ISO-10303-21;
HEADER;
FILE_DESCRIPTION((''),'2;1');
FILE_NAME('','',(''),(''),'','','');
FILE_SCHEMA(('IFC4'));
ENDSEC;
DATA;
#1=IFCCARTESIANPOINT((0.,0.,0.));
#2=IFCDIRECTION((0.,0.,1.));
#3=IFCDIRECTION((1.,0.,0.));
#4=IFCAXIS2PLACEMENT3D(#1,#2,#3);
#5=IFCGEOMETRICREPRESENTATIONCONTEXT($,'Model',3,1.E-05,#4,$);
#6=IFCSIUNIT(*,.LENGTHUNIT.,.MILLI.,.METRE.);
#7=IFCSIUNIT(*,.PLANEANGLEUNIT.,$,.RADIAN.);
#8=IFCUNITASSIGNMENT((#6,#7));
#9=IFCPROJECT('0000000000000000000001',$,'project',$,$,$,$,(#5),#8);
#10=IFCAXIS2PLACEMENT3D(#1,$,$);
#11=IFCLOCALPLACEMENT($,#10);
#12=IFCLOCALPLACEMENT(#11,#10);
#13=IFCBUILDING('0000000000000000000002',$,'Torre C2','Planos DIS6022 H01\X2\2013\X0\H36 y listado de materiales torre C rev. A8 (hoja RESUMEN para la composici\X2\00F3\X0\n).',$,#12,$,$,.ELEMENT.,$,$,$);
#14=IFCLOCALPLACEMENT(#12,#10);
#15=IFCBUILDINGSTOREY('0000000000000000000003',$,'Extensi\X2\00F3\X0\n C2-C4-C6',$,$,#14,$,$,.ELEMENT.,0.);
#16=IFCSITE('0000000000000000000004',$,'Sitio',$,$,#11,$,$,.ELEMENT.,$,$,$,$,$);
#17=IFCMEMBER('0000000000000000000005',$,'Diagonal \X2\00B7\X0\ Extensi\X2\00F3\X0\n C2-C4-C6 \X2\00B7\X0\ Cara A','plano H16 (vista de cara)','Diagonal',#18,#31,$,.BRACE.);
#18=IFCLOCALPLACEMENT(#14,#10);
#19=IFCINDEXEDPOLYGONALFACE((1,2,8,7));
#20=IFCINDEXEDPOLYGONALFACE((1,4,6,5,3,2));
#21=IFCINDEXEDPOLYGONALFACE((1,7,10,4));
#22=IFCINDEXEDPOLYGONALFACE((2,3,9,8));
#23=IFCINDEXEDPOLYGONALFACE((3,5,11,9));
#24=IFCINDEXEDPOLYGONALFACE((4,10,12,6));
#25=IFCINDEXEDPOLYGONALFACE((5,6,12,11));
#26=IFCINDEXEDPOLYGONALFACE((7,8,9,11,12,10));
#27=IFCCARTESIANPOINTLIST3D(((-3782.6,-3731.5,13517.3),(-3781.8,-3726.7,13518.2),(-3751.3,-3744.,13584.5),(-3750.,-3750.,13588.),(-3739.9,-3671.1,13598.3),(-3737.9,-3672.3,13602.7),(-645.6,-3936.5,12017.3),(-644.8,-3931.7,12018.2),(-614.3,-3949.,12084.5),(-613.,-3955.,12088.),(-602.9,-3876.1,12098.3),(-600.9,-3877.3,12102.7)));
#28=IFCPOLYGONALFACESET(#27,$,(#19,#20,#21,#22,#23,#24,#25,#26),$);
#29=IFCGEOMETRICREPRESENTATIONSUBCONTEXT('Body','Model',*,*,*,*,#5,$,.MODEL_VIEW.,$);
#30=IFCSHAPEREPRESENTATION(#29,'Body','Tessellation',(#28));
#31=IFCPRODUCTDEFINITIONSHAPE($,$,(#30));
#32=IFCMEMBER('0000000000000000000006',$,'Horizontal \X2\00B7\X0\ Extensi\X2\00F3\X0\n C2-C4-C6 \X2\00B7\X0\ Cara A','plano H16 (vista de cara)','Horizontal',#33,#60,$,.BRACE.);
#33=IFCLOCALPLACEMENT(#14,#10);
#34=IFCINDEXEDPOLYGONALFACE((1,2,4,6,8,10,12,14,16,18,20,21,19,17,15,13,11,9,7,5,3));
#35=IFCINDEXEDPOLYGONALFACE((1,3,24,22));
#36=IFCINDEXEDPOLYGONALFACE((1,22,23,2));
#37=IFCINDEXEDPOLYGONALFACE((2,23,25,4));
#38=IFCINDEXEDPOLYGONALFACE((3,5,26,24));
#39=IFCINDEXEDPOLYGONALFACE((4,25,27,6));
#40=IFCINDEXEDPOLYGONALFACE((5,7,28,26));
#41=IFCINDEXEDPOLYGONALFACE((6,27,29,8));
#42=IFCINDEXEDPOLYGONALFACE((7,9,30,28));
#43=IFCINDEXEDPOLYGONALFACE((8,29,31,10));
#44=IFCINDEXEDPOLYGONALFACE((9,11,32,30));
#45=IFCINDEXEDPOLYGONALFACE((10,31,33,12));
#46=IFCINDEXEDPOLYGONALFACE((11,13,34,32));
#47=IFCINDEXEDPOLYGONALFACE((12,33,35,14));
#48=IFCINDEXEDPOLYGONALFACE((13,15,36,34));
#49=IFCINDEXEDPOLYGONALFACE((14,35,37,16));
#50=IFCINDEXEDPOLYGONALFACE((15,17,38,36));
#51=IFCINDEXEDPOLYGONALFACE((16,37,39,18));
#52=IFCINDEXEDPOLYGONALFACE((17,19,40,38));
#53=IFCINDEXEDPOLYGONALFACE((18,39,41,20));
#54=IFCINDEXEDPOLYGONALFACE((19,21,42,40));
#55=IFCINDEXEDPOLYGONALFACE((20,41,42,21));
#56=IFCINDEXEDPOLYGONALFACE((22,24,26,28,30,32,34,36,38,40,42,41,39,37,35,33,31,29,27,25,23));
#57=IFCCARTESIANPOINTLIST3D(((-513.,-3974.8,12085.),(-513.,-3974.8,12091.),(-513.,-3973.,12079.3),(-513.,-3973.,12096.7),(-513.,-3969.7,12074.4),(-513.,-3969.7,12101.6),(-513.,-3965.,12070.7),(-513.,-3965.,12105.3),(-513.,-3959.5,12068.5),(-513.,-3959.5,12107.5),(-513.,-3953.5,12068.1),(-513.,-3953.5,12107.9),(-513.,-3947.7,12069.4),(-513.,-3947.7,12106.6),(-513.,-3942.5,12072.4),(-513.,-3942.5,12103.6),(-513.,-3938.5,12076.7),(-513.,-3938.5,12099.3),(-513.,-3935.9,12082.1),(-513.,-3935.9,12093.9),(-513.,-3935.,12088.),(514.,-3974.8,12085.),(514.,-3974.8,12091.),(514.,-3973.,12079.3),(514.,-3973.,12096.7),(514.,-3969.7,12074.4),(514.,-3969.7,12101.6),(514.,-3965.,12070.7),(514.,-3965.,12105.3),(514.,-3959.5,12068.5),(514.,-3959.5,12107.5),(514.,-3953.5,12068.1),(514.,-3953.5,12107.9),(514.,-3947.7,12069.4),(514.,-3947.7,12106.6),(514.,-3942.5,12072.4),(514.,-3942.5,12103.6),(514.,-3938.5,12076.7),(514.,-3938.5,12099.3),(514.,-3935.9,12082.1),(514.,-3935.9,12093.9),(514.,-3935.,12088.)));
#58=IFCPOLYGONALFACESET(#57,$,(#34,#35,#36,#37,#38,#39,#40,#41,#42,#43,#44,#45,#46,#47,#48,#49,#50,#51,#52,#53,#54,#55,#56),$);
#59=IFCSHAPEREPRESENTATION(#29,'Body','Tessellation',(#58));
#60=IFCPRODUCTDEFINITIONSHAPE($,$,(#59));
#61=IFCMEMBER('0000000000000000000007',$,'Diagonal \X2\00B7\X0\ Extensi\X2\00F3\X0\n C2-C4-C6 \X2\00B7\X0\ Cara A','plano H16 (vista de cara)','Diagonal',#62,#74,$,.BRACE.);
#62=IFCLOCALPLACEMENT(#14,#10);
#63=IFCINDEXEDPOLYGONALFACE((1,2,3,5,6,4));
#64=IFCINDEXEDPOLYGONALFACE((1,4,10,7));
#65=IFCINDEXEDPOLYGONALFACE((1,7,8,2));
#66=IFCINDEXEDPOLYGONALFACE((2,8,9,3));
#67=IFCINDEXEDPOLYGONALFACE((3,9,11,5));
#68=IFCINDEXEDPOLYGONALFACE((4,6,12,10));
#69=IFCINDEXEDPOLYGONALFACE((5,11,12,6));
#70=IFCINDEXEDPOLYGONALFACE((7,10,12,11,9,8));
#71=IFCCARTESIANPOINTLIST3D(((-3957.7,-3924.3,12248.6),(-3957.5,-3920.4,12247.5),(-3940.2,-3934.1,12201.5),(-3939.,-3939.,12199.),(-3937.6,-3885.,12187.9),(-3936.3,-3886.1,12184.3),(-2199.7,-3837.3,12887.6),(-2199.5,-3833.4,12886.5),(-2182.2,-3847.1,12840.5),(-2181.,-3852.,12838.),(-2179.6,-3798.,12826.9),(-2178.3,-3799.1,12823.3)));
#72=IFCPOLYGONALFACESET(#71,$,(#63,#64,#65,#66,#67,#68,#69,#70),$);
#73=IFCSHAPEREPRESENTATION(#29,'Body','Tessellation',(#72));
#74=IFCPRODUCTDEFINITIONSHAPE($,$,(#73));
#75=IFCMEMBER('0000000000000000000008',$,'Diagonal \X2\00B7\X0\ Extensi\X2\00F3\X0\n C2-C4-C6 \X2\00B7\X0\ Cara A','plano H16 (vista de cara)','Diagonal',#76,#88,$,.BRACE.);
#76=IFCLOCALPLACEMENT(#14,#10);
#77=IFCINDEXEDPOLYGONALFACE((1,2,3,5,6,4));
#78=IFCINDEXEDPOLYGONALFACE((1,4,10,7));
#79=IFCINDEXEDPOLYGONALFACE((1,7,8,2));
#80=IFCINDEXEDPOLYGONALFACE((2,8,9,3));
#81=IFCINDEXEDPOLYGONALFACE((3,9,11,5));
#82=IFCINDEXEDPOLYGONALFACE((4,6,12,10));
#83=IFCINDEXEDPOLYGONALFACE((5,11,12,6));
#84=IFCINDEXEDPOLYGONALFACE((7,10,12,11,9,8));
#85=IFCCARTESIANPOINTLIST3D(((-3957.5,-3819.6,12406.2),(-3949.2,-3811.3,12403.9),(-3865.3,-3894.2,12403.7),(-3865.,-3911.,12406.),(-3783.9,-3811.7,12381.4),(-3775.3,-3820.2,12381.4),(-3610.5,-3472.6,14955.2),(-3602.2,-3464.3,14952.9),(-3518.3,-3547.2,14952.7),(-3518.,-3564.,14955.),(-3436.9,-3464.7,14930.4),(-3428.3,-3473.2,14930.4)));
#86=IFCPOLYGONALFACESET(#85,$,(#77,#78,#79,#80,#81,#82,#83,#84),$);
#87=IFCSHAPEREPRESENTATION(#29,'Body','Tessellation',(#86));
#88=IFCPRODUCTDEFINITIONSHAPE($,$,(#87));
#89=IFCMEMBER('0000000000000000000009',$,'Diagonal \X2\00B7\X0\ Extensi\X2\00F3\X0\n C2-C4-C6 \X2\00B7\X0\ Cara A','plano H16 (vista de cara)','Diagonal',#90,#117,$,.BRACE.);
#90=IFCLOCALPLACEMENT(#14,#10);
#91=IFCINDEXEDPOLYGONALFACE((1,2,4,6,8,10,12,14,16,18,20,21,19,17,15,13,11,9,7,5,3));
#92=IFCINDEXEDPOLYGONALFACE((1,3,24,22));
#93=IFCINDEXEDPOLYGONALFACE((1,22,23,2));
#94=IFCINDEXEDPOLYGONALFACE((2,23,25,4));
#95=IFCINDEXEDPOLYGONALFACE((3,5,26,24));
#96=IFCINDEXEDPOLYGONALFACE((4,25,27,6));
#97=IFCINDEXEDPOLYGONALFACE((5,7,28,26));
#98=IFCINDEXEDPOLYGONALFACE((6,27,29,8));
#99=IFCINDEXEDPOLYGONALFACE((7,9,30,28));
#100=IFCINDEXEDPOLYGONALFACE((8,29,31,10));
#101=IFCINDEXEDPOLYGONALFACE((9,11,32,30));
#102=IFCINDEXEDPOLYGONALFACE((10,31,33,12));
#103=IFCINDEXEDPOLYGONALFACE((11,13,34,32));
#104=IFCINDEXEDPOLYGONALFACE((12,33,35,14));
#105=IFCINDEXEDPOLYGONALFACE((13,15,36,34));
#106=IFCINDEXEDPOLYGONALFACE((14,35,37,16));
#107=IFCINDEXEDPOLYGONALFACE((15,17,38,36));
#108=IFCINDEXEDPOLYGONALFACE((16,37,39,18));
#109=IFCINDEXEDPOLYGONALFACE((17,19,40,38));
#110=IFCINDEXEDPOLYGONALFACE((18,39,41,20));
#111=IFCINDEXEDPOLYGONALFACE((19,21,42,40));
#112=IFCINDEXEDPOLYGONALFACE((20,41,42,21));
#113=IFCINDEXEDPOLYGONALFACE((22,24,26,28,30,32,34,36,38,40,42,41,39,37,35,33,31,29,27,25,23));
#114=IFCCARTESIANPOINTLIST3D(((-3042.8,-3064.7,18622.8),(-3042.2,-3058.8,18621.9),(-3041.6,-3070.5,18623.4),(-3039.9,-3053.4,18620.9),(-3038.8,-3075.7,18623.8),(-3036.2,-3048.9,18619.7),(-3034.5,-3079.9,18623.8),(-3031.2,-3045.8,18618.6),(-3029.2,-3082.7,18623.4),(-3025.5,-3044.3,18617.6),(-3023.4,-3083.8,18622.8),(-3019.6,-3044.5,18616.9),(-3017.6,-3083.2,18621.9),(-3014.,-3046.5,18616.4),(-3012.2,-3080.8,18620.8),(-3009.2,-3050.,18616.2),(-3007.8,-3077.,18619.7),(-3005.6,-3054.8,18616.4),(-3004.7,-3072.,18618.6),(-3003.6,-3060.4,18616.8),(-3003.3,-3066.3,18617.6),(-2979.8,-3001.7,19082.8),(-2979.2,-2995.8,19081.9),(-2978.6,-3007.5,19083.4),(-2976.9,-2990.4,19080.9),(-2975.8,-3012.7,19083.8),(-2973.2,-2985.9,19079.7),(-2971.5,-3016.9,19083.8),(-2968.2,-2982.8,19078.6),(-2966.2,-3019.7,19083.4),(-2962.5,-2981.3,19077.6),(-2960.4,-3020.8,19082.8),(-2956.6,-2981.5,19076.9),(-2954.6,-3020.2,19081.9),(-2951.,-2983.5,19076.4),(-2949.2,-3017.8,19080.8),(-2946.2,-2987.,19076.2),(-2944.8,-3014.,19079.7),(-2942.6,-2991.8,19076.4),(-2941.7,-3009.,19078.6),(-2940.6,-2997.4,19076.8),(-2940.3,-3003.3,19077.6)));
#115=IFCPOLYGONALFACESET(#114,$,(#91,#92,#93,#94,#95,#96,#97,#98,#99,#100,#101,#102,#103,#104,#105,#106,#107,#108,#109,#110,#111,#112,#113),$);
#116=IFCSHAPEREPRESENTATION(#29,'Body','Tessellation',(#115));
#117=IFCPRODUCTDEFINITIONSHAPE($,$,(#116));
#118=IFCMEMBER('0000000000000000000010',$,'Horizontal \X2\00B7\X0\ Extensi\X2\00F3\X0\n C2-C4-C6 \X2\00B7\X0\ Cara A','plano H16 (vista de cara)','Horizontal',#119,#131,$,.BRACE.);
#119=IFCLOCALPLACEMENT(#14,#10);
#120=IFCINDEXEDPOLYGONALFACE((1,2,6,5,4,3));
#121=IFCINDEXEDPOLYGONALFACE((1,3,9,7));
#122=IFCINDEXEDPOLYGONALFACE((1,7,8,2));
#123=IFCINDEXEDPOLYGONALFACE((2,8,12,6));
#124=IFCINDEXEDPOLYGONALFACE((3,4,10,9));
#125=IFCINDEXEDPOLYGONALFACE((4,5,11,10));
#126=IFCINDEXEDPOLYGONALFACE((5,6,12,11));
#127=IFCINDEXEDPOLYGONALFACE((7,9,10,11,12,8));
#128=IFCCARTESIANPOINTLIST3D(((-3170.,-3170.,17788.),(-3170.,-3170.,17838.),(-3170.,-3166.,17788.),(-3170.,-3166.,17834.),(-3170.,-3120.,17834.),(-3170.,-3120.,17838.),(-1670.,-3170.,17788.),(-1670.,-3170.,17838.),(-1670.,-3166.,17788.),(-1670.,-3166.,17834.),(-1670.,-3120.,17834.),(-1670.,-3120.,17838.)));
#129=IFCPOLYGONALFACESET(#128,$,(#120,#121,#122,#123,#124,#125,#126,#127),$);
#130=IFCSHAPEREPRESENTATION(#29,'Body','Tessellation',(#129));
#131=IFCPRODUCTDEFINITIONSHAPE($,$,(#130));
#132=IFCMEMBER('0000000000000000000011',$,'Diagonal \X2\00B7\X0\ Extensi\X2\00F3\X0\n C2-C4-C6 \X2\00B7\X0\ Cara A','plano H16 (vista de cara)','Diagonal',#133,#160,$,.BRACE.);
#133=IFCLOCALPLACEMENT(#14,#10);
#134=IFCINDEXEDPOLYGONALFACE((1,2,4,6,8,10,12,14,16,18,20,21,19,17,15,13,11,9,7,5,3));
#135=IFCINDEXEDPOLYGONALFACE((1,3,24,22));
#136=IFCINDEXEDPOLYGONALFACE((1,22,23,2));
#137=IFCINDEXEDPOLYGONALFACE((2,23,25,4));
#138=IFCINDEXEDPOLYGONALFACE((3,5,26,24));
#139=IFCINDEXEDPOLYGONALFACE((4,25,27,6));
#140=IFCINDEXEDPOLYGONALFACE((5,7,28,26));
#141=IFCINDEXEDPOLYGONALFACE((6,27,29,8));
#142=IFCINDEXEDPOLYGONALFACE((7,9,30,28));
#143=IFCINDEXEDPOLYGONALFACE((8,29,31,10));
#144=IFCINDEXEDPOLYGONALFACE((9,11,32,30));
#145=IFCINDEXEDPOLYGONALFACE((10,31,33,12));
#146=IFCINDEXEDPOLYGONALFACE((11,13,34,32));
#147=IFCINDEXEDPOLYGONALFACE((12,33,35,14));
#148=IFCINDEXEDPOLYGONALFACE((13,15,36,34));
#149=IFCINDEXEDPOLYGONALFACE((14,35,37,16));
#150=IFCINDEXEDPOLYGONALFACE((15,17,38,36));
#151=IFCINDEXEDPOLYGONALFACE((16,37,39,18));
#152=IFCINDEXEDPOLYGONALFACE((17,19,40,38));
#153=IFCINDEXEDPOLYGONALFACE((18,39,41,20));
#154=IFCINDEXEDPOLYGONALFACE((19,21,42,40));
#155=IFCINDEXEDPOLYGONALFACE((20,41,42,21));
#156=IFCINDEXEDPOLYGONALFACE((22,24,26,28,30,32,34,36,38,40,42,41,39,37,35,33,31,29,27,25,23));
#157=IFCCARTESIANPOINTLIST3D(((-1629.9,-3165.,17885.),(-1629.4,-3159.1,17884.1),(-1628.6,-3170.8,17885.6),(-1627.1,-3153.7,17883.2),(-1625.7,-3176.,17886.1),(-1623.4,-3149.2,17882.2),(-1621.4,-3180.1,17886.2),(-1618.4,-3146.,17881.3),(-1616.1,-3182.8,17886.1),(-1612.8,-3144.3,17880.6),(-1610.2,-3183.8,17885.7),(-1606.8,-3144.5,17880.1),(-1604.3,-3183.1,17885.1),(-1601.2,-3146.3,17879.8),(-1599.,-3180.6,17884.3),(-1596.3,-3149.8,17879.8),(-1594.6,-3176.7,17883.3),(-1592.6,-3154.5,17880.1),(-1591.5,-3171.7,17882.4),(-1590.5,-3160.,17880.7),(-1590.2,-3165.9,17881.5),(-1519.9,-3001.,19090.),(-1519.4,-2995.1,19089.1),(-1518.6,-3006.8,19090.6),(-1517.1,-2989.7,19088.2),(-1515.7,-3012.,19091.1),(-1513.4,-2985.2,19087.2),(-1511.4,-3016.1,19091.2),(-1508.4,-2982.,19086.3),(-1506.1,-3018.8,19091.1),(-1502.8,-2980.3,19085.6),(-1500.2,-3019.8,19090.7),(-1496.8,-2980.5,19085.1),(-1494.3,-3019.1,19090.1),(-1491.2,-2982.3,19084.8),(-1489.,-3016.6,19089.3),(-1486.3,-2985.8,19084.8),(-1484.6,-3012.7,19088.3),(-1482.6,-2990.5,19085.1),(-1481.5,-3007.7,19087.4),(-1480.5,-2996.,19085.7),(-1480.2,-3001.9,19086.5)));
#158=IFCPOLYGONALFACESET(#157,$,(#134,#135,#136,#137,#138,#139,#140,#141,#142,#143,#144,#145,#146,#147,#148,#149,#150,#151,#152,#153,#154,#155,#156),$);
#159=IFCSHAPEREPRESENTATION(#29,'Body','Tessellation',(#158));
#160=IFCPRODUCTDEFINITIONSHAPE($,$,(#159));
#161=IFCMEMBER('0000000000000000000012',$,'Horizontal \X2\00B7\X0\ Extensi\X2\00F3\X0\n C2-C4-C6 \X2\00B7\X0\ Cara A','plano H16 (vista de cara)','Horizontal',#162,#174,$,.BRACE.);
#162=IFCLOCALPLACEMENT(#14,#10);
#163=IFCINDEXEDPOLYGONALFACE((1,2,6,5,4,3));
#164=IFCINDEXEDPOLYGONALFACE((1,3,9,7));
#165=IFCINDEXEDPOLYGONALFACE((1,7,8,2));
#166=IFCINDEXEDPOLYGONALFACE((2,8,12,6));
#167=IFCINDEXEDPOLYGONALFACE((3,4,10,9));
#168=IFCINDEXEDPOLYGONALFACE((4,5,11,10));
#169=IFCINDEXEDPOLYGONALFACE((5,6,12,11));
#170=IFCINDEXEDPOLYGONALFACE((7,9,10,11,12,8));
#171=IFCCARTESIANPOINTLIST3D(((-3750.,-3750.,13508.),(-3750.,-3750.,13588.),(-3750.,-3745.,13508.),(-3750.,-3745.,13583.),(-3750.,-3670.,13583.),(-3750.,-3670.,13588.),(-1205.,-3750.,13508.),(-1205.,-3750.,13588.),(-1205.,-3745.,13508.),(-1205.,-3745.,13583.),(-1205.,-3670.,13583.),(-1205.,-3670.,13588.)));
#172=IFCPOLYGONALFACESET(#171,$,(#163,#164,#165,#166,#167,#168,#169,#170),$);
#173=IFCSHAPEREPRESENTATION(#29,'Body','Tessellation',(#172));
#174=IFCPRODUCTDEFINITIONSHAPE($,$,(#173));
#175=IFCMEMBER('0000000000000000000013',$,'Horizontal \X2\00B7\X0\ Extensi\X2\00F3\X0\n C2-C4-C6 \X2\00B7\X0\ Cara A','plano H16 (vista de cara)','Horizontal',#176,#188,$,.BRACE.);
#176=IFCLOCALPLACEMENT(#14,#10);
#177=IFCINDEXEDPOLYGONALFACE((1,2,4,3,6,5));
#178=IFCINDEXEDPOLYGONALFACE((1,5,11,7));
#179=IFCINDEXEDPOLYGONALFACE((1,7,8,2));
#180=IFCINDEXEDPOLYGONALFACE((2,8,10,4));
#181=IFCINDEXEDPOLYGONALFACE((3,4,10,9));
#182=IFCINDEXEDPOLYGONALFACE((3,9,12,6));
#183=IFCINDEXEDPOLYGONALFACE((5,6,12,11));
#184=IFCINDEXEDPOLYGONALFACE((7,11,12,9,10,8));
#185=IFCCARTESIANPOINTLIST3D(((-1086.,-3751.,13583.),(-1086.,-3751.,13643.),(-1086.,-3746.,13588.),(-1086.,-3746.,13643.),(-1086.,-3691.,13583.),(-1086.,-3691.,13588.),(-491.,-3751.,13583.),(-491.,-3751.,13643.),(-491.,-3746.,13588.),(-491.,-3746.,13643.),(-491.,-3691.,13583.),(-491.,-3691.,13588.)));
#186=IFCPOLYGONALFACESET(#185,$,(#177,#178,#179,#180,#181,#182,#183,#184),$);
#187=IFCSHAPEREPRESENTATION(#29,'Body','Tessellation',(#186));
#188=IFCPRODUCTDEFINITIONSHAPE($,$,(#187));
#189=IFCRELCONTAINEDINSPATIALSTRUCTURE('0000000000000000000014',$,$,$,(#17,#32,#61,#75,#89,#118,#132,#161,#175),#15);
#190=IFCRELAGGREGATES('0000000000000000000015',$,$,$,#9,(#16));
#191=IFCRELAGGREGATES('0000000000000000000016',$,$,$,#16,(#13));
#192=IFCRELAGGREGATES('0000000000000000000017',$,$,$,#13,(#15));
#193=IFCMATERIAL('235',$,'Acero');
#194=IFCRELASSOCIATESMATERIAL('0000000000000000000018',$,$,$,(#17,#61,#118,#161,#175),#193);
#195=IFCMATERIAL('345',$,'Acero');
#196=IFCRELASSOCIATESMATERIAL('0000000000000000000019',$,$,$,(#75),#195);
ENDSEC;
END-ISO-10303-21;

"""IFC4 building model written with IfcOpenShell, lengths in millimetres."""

from ifc_helpers import new_model, si_unit, frame, frame_2d, origin, origin_with_axes, place, context, subcontext, project, spatial, circle, l_section, extrude, material, element, save


model = new_model("IFC4")

# Units and contexts
model_context = context("Model", 3, precision=1e-05, world=origin_with_axes())
body_context = subcontext(model_context, "Body", "Model", "MODEL_VIEW")
ifc_project = project(units=[si_unit("LENGTHUNIT", "METRE", prefix="MILLI"), si_unit("PLANEANGLEUNIT", "RADIAN")], contexts=[model_context])

# Site, building, storey
site_placement = place(None, origin())
site = spatial("IfcSite", under=ifc_project, at=site_placement, Name="Sitio", CompositionType="ELEMENT")
building_placement = place(site_placement, origin())
building = spatial("IfcBuilding", under=site, at=building_placement, Name="Torre C2", Description="Planos DIS6022 H01–H36 y listado de materiales torre C rev. A8 (hoja RESUMEN para la composición).", CompositionType="ELEMENT")
storey_placement = place(building_placement, origin())
storey = spatial("IfcBuildingStorey", under=building, at=storey_placement, Name="Extensión C2-C4-C6", CompositionType="ELEMENT", Elevation=0.0)

# Members
ifc_material_1 = material(Name="235", Category="Acero")
member_1_placement = place(storey_placement, frame((-613.0, -3955.0, 12088.0), z_axis=(-0.900604, 0.058854, 0.430637), x_axis=(0.151357, 0.971241, 0.183801)))
element("IfcMember", 1, at=member_1_placement, inside=storey, material=ifc_material_1, Name="Diagonal · Extensión C2-C4-C6 · Cara A", Description="plano H16 (vista de cara)", ObjectType="Diagonal", PredefinedType="BRACE", context=body_context, shape_type="SweptSolid", body=[
    extrude(l_section(Depth=80.0, Width=80.0, Thickness=5.0, at=frame_2d((40.0, 40.0))), None, (0.0, 0.0, 1.0), 3483.2),
])
member_2_placement = place(storey_placement, frame((-513.0, -3955.0, 12088.0), z_axis=(1.0, 0.0, 0.0), x_axis=(0.0, 1.0, 0.0)))
element("IfcMember", 2, at=member_2_placement, inside=storey, Name="Horizontal · Extensión C2-C4-C6 · Cara A", Description="plano H16 (vista de cara)", ObjectType="Horizontal", PredefinedType="BRACE", context=body_context, shape_type="SweptSolid", body=[
    extrude(circle(Radius=20.0), None, (0.0, 0.0, 1.0), 1027.0),
])
member_3_placement = place(storey_placement, frame((-3939.0, -3939.0, 12199.0), z_axis=(0.938825, 0.046461, 0.341245), x_axis=(0.049488, 0.962376, -0.267178)))
element("IfcMember", 3, at=member_3_placement, inside=storey, material=ifc_material_1, Name="Diagonal · Extensión C2-C4-C6 · Cara A", Description="plano H16 (vista de cara)", ObjectType="Diagonal", PredefinedType="BRACE", context=body_context, shape_type="SweptSolid", body=[
    extrude(l_section(Depth=55.0, Width=55.0, Thickness=4.0, at=frame_2d((27.5, 27.5))), None, (0.0, 0.0, 1.0), 1872.6),
])
ifc_material_2 = material(Name="345", Category="Acero")
member_4_placement = place(storey_placement, frame((-3865.0, -3911.0, 12406.0), z_axis=(0.133677, 0.133677, 0.981968), x_axis=(0.689884, 0.698801, -0.189044)))
element("IfcMember", 4, at=member_4_placement, inside=storey, material=ifc_material_2, Name="Diagonal · Extensión C2-C4-C6 · Cara A", Description="plano H16 (vista de cara)", ObjectType="Diagonal", PredefinedType="BRACE", context=body_context, shape_type="SweptSolid", body=[
    extrude(l_section(Depth=130.0, Width=130.0, Thickness=12.0, at=frame_2d((65.0, 65.0))), None, (0.0, 0.0, 1.0), 2595.8),
])
member_5_placement = place(storey_placement, frame((-2960.0, -3001.0, 19080.0), z_axis=(-0.134458, -0.134458, -0.981755), x_axis=(0.689287, 0.699091, -0.190147)))
element("IfcMember", 5, at=member_5_placement, inside=storey, Name="Diagonal · Extensión C2-C4-C6 · Cara A", Description="plano H16 (vista de cara)", ObjectType="Diagonal", PredefinedType="BRACE", context=body_context, shape_type="SweptSolid", body=[
    extrude(circle(Radius=20.0), None, (0.0, 0.0, 1.0), 468.5),
])
member_6_placement = place(storey_placement, frame((-1670.0, -3170.0, 17838.0), z_axis=(-1.0, 0.0, 0.0), x_axis=(0.0, 1.0, 0.0)))
element("IfcMember", 6, at=member_6_placement, inside=storey, material=ifc_material_1, Name="Horizontal · Extensión C2-C4-C6 · Cara A", Description="plano H16 (vista de cara)", ObjectType="Horizontal", PredefinedType="BRACE", context=body_context, shape_type="SweptSolid", body=[
    extrude(l_section(Depth=50.0, Width=50.0, Thickness=4.0, at=frame_2d((25.0, 25.0))), None, (0.0, 0.0, 1.0), 1500.0),
])
member_7_placement = place(storey_placement, frame((-1500.0, -3000.0, 19088.0), z_axis=(-0.090085, -0.134308, -0.986836), x_axis=(0.441723, 0.882686, -0.160456)))
element("IfcMember", 7, at=member_7_placement, inside=storey, Name="Diagonal · Extensión C2-C4-C6 · Cara A", Description="plano H16 (vista de cara)", ObjectType="Diagonal", PredefinedType="BRACE", context=body_context, shape_type="SweptSolid", body=[
    extrude(circle(Radius=20.0), None, (0.0, 0.0, 1.0), 1221.1),
])
member_8_placement = place(storey_placement, frame((-1205.0, -3750.0, 13588.0), z_axis=(-1.0, 0.0, 0.0), x_axis=(0.0, 1.0, 0.0)))
element("IfcMember", 8, at=member_8_placement, inside=storey, material=ifc_material_1, Name="Horizontal · Extensión C2-C4-C6 · Cara A", Description="plano H16 (vista de cara)", ObjectType="Horizontal", PredefinedType="BRACE", context=body_context, shape_type="SweptSolid", body=[
    extrude(l_section(Depth=80.0, Width=80.0, Thickness=5.0, at=frame_2d((40.0, 40.0))), None, (0.0, 0.0, 1.0), 2545.0),
])
member_9_placement = place(storey_placement, frame((-1086.0, -3751.0, 13583.0), z_axis=(1.0, 0.0, 0.0), x_axis=(0.0, 1.0, 0.0)))
element("IfcMember", 9, at=member_9_placement, inside=storey, material=ifc_material_1, Name="Horizontal · Extensión C2-C4-C6 · Cara A", Description="plano H16 (vista de cara)", ObjectType="Horizontal", PredefinedType="BRACE", context=body_context, shape_type="SweptSolid", body=[
    extrude(l_section(Depth=60.0, Width=60.0, Thickness=5.0, at=frame_2d((30.0, 30.0))), None, (0.0, 0.0, 1.0), 595.0),
])

save(model, "model.ifc")
